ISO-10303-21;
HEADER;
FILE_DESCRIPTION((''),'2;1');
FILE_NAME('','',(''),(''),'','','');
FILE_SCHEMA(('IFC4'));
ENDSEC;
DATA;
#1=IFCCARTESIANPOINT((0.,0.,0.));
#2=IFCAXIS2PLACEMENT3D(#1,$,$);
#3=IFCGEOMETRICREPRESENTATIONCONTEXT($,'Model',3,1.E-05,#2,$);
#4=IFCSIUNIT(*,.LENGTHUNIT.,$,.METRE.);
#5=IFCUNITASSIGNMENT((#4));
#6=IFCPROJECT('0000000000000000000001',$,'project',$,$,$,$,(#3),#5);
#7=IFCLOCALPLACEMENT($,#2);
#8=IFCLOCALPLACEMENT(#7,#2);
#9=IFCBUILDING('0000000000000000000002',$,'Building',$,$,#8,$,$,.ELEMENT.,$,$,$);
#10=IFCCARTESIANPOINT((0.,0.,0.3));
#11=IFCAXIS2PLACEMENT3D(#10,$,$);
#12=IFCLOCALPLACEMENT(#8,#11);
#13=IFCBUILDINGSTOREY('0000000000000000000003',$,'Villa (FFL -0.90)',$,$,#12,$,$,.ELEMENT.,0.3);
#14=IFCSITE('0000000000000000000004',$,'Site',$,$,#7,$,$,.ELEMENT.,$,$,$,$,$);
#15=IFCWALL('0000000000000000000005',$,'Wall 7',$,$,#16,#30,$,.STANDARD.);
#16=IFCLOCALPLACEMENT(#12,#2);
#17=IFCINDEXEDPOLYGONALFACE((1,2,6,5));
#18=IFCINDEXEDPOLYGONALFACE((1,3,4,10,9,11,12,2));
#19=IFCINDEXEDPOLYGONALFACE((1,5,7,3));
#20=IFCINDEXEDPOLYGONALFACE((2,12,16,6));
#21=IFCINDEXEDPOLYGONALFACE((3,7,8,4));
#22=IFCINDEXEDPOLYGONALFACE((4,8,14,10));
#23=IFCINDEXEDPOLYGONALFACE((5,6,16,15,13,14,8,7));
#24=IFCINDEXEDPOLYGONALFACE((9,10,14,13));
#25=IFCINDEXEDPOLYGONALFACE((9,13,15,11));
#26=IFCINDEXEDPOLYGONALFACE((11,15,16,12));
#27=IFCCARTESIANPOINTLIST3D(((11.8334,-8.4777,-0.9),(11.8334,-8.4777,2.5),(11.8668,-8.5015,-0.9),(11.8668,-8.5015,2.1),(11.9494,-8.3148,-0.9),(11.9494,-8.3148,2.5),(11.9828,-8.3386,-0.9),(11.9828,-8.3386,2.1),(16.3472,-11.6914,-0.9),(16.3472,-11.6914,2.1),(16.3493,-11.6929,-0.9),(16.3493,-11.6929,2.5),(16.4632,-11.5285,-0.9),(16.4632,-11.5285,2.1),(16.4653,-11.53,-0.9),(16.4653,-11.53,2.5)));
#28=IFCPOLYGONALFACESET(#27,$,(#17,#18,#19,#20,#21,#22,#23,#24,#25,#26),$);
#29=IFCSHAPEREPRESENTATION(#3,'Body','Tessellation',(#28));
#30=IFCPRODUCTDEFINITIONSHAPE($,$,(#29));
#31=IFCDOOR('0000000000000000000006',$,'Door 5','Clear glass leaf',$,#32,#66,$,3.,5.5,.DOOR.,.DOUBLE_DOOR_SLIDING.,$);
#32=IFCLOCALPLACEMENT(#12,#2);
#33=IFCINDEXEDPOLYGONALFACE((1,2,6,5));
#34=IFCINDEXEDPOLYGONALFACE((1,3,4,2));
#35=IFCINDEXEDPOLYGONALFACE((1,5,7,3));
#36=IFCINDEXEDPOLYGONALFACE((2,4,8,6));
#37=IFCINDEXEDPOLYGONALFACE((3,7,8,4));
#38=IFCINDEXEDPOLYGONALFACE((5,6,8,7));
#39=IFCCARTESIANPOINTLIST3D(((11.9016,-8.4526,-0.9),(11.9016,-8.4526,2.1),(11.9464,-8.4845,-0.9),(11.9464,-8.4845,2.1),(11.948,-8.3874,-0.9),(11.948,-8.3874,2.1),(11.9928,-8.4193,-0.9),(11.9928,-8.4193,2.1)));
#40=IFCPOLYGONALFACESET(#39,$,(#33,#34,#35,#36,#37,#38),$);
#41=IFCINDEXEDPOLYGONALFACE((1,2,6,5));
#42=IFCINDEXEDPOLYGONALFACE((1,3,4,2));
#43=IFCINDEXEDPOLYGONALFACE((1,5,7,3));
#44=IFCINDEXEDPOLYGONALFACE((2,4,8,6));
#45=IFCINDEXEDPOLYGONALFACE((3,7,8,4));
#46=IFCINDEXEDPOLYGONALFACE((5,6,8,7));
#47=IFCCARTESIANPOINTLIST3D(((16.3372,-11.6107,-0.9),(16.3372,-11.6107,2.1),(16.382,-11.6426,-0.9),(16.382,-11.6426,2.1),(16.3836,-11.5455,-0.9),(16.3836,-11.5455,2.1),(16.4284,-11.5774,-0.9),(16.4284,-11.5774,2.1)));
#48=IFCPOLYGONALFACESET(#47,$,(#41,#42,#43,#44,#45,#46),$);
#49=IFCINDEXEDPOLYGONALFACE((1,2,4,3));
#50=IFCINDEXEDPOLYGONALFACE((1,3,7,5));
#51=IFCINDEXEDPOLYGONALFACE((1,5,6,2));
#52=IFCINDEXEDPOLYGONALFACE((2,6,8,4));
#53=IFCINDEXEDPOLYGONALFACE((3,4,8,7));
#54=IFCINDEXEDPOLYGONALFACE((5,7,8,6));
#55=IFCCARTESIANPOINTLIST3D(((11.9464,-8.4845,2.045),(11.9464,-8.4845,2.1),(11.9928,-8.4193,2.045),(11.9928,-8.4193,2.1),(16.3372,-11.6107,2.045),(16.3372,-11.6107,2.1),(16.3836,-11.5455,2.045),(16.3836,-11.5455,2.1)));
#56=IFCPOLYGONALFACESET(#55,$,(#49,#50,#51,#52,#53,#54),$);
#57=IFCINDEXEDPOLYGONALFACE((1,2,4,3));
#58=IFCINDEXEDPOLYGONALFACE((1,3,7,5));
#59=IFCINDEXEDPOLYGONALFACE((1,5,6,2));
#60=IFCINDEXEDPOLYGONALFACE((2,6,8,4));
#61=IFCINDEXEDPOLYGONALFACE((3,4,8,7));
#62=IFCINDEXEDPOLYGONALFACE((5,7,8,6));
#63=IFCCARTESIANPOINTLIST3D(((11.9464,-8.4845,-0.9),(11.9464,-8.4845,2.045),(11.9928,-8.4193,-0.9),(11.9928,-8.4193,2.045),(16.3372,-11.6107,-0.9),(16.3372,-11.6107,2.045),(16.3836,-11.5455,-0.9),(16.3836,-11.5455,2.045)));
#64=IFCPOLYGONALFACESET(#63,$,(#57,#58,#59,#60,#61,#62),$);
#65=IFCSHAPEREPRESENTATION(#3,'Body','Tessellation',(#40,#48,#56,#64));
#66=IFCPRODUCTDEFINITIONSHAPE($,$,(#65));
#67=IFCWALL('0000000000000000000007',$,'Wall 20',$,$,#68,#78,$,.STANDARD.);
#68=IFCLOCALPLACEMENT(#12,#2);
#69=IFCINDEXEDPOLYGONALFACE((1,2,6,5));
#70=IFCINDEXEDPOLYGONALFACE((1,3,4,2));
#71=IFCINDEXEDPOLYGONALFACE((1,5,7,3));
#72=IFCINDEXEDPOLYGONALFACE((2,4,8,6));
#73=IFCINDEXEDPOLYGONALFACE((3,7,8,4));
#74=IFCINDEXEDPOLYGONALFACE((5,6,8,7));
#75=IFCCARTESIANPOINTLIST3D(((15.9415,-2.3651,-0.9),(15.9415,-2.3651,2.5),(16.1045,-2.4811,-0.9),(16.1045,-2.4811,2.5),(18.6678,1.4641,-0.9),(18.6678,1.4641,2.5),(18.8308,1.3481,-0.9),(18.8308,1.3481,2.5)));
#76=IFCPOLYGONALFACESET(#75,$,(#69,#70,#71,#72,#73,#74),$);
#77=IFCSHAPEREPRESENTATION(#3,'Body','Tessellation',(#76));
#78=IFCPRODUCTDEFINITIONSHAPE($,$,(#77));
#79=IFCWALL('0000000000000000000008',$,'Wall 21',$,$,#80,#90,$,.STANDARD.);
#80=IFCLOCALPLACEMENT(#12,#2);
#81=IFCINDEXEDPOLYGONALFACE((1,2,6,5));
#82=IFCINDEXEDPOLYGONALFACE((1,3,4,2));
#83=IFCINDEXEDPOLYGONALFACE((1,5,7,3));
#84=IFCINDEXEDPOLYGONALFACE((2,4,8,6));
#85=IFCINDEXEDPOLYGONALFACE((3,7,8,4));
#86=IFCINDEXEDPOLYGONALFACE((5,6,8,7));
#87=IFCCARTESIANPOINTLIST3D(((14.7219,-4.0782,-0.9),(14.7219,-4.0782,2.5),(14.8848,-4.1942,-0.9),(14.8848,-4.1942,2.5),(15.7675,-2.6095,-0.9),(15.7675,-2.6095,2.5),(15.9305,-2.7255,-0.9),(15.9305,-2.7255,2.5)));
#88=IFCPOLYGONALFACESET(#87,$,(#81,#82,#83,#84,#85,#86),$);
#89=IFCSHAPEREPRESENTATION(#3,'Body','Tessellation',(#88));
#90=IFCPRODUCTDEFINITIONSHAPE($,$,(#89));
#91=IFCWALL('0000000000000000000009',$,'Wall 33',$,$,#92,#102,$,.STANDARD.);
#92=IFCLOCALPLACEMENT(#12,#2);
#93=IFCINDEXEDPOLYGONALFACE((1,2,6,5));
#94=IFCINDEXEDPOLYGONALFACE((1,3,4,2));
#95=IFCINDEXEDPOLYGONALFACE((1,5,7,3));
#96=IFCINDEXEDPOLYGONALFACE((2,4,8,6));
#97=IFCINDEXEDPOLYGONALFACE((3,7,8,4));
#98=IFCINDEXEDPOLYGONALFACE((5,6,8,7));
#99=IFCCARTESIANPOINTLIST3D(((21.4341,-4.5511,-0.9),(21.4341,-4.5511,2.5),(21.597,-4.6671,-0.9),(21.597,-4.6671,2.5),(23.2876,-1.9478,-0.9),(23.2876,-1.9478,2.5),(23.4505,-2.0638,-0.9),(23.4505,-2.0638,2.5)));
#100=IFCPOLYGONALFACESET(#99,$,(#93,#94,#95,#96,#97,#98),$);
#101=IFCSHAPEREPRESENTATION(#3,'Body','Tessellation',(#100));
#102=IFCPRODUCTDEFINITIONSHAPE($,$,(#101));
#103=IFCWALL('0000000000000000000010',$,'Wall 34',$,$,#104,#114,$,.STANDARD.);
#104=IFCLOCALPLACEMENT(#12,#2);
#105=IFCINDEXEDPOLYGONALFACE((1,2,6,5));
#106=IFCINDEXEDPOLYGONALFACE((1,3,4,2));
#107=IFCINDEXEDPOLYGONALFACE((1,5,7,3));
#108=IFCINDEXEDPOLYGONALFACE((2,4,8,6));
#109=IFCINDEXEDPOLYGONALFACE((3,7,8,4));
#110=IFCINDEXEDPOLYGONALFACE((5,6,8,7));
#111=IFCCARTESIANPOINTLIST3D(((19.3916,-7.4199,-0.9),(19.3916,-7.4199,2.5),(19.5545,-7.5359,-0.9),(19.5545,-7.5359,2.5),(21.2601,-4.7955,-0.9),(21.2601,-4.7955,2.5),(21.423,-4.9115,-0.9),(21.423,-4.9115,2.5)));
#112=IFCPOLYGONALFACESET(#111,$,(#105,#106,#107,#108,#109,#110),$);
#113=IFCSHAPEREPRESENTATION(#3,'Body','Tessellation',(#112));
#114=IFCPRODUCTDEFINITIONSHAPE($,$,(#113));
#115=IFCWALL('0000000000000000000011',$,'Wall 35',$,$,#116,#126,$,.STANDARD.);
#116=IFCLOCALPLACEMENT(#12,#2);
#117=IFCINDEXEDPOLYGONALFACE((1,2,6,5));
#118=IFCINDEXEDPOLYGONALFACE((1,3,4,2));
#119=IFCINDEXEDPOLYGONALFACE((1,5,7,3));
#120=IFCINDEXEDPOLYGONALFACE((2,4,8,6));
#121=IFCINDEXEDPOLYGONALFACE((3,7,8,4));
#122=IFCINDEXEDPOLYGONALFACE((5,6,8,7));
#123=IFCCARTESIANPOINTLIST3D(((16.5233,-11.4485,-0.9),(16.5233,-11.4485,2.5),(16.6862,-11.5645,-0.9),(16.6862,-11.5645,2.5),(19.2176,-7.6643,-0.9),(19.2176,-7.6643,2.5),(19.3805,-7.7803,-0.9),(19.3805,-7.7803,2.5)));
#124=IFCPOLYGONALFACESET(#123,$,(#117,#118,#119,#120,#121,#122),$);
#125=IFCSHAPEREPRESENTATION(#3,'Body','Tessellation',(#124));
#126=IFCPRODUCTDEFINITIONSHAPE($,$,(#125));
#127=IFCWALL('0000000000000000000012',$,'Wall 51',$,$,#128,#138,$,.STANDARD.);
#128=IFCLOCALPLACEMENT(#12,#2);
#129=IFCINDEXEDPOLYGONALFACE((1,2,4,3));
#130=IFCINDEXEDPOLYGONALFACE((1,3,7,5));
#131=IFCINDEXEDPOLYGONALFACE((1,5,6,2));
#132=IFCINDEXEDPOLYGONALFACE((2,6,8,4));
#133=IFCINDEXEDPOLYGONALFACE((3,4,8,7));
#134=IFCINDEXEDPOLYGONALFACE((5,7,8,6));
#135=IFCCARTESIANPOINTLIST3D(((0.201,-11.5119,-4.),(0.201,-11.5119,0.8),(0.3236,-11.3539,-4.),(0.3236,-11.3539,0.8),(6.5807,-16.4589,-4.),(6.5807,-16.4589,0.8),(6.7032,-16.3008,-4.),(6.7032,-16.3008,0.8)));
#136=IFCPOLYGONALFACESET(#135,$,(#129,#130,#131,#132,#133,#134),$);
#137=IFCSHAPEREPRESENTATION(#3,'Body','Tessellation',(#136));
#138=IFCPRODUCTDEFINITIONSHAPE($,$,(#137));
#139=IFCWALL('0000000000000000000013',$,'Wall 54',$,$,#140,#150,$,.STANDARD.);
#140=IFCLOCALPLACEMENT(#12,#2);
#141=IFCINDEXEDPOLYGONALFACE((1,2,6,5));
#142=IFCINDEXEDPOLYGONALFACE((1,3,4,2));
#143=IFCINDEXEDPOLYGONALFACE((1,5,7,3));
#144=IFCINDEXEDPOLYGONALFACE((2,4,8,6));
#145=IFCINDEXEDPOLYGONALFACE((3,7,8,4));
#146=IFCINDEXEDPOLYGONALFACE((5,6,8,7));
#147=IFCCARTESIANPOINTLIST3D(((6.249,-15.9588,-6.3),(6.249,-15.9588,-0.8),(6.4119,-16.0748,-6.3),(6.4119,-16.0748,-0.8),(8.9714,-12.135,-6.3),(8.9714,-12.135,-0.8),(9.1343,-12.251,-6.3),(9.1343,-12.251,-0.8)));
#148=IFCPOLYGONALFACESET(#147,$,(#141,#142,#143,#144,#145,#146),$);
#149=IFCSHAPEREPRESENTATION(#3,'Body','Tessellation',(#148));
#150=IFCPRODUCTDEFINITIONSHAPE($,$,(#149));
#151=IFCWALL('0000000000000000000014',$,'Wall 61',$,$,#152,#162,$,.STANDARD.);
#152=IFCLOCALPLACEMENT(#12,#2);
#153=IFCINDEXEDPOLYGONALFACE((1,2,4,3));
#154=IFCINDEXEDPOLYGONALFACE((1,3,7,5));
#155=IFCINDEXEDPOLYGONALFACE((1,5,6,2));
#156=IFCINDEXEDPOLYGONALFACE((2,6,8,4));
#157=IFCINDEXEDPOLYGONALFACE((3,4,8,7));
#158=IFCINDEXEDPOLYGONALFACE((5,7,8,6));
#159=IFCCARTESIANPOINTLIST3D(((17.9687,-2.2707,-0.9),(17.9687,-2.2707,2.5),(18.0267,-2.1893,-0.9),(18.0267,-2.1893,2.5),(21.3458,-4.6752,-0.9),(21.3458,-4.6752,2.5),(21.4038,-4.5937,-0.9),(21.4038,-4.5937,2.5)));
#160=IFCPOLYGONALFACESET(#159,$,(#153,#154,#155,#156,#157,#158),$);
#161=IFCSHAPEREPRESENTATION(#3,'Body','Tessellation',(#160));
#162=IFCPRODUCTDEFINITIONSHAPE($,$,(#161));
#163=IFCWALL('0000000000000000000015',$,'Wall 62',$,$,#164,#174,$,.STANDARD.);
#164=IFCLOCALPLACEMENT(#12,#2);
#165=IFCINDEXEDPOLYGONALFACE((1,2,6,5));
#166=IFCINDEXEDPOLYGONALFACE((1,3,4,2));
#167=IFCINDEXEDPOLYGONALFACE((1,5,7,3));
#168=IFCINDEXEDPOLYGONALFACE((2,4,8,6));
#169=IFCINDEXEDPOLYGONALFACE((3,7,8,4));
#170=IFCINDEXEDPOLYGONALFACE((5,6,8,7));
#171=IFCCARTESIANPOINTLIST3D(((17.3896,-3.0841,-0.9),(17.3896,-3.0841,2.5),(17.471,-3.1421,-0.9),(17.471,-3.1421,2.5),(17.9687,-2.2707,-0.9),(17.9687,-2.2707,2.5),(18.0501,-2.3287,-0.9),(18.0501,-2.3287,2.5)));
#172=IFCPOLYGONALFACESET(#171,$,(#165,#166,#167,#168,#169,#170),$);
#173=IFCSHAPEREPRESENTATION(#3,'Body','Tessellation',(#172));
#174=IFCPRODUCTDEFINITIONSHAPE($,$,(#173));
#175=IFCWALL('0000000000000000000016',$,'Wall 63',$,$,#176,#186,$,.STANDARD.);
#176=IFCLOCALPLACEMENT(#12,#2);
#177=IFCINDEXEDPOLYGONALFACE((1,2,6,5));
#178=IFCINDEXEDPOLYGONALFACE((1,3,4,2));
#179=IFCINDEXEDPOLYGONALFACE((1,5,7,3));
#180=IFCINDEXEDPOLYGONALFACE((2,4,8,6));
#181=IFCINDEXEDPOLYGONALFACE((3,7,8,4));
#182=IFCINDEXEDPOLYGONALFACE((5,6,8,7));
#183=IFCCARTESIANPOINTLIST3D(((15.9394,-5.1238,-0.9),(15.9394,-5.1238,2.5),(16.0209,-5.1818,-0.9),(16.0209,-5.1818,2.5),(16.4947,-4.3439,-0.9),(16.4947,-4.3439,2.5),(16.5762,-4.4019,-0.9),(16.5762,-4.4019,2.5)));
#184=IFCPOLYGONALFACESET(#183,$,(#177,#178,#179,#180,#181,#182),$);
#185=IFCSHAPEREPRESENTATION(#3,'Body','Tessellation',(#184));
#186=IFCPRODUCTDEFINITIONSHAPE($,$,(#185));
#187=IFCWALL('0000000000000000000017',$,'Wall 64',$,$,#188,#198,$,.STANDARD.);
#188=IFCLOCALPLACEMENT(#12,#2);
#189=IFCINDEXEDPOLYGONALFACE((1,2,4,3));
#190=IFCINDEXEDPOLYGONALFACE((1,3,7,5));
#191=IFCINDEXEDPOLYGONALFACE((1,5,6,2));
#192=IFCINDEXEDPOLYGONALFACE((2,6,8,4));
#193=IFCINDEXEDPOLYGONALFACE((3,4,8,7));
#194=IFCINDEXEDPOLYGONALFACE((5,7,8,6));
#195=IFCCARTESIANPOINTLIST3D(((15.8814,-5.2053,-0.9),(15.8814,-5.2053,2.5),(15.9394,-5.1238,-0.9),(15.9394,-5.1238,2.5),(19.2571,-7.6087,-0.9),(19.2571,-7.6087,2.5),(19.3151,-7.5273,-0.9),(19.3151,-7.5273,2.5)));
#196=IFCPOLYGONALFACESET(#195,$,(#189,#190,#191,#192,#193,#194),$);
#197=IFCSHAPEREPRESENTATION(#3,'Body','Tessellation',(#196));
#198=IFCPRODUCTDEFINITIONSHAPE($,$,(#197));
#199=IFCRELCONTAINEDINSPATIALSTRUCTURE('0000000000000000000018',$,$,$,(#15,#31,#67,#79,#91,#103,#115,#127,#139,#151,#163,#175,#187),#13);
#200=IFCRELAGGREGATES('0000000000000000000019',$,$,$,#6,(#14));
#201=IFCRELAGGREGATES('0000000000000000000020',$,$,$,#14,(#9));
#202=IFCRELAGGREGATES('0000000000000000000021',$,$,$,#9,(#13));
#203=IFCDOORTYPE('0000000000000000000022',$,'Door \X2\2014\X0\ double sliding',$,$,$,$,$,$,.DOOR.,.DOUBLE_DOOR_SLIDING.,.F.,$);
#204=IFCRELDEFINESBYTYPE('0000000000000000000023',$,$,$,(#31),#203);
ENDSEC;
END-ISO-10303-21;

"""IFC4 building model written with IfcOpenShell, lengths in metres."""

from ifc_helpers import new_model, si_unit, frame, frame_2d, origin, place, context, project, spatial, rectangle, extrude, type_object, element, fill, save


model = new_model("IFC4")

# Units and contexts
model_context = context("Model", 3, precision=1e-05, world=origin())
ifc_project = project(units=[si_unit("LENGTHUNIT", "METRE")], contexts=[model_context])

# Site, building, storey
site_placement = place(None, origin())
site = spatial("IfcSite", under=ifc_project, at=site_placement, Name="Site", CompositionType="ELEMENT")
building_placement = place(site_placement, origin())
building = spatial("IfcBuilding", under=site, at=building_placement, Name="Building", CompositionType="ELEMENT")
storey_placement = place(building_placement, frame((0.0, 0.0, 0.3)))
storey = spatial("IfcBuildingStorey", under=building, at=storey_placement, Name="Villa (FFL -0.90)", CompositionType="ELEMENT", Elevation=0.3)

# Wall, opening, door
door_type = type_object("IfcDoorType", Name="Door — double sliding", OperationType="DOUBLE_DOOR_SLIDING", ParameterTakesPrecedence=False, PredefinedType="DOOR")
wall_1_placement = place(storey_placement, frame((11.8914, -8.3962, -0.9), z_axis=(0.0, 0.0, 1.0), x_axis=(0.814622, -0.579992, 0.0)))
wall_1 = element("IfcWall", 1, at=wall_1_placement, inside=storey, Name="Wall 7", PredefinedType="STANDARD", context=model_context, shape_type="SweptSolid", body=[
    extrude(rectangle(XDim=5.5436, YDim=0.2, at=frame_2d((2.7718, 0.0))), origin(), (0.0, 0.0, 1.0), 3.4),
])
opening_1_placement = place(storey_placement, frame((11.9248, -8.42, -0.9), z_axis=(0.0, 0.0, 1.0), x_axis=(0.814622, -0.579992, 0.0)))
opening_1 = element("IfcOpeningElement", 2, at=opening_1_placement, cuts=wall_1, PredefinedType="OPENING", context=model_context, shape_type="SweptSolid", body=[
    extrude(rectangle(XDim=5.5, YDim=0.26, at=frame_2d((2.75, 0.0))), origin(), (0.0, 0.0, 1.0), 3.0),
])
door_1_placement = place(storey_placement, frame((11.9248, -8.42, -0.9), z_axis=(0.0, 0.0, 1.0), x_axis=(0.814622, -0.579992, 0.0)))
door_1 = element("IfcDoor", 3, at=door_1_placement, inside=storey, type_object=door_type, Name="Door 5", Description="Clear glass leaf", OperationType="DOUBLE_DOOR_SLIDING", OverallHeight=3.0, OverallWidth=5.5, PredefinedType="DOOR", context=model_context, shape_type="SweptSolid", body=[
    extrude(rectangle(XDim=0.055, YDim=0.08, at=frame_2d((0.0275, 0.0))), origin(), (0.0, 0.0, 1.0), 3.0),
    extrude(rectangle(XDim=0.055, YDim=0.08, at=frame_2d((5.4725, 0.0))), origin(), (0.0, 0.0, 1.0), 3.0),
    extrude(rectangle(XDim=5.39, YDim=0.08, at=frame_2d((2.75, 0.0))), frame((0.0, 0.0, 2.945)), (0.0, 0.0, 1.0), 0.055),
    extrude(rectangle(XDim=5.39, YDim=0.08, at=frame_2d((2.75, 0.0))), origin(), (0.0, 0.0, 1.0), 2.945),
])
fill(opening_1, door_1)

# Walls
wall_2_placement = place(storey_placement, frame((16.023, -2.4231, -0.9), z_axis=(0.0, 0.0, 1.0), x_axis=(0.579992, 0.814622, 0.0)))
element("IfcWall", 4, at=wall_2_placement, inside=storey, Name="Wall 20", PredefinedType="STANDARD", context=model_context, shape_type="SweptSolid", body=[
    extrude(rectangle(XDim=4.7006, YDim=0.2, at=frame_2d((2.3503, 0.0))), origin(), (0.0, 0.0, 1.0), 3.4),
])
wall_3_placement = place(storey_placement, frame((14.8033, -4.1362, -0.9), z_axis=(0.0, 0.0, 1.0), x_axis=(0.579992, 0.814622, 0.0)))
element("IfcWall", 5, at=wall_3_placement, inside=storey, Name="Wall 21", PredefinedType="STANDARD", context=model_context, shape_type="SweptSolid", body=[
    extrude(rectangle(XDim=1.8029, YDim=0.2, at=frame_2d((0.9014, 0.0))), origin(), (0.0, 0.0, 1.0), 3.4),
])
wall_4_placement = place(storey_placement, frame((21.5156, -4.6091, -0.9), z_axis=(0.0, 0.0, 1.0), x_axis=(0.579992, 0.814622, 0.0)))
element("IfcWall", 6, at=wall_4_placement, inside=storey, Name="Wall 33", PredefinedType="STANDARD", context=model_context, shape_type="SweptSolid", body=[
    extrude(rectangle(XDim=3.1957, YDim=0.2, at=frame_2d((1.5978, 0.0))), origin(), (0.0, 0.0, 1.0), 3.4),
])
wall_5_placement = place(storey_placement, frame((19.473, -7.4779, -0.9), z_axis=(0.0, 0.0, 1.0), x_axis=(0.579992, 0.814622, 0.0)))
element("IfcWall", 7, at=wall_5_placement, inside=storey, Name="Wall 34", PredefinedType="STANDARD", context=model_context, shape_type="SweptSolid", body=[
    extrude(rectangle(XDim=3.2217, YDim=0.2, at=frame_2d((1.6108, 0.0))), origin(), (0.0, 0.0, 1.0), 3.4),
])
wall_6_placement = place(storey_placement, frame((16.6047, -11.5065, -0.9), z_axis=(0.0, 0.0, 1.0), x_axis=(0.579992, 0.814622, 0.0)))
element("IfcWall", 8, at=wall_6_placement, inside=storey, Name="Wall 35", PredefinedType="STANDARD", context=model_context, shape_type="SweptSolid", body=[
    extrude(rectangle(XDim=4.6454, YDim=0.2, at=frame_2d((2.3227, 0.0))), origin(), (0.0, 0.0, 1.0), 3.4),
])
wall_7_placement = place(storey_placement, frame((0.2623, -11.4329, -4.0), z_axis=(0.0, 0.0, 1.0), x_axis=(0.790251, -0.612783, 0.0)))
element("IfcWall", 9, at=wall_7_placement, inside=storey, Name="Wall 51", PredefinedType="STANDARD", context=model_context, shape_type="SweptSolid", body=[
    extrude(rectangle(XDim=8.0729, YDim=0.2, at=frame_2d((4.0365, 0.0))), origin(), (0.0, 0.0, 1.0), 4.8),
])
wall_8_placement = place(storey_placement, frame((9.0529, -12.193, -6.3), z_axis=(0.0, 0.0, 1.0), x_axis=(-0.579992, -0.814622, 0.0)))
element("IfcWall", 10, at=wall_8_placement, inside=storey, Name="Wall 54", PredefinedType="STANDARD", context=model_context, shape_type="SweptSolid", body=[
    extrude(rectangle(XDim=4.6939, YDim=0.2, at=frame_2d((2.347, 0.0))), origin(), (0.0, 0.0, 1.0), 5.5),
])
wall_9_placement = place(storey_placement, frame((17.9977, -2.23, -0.9), z_axis=(0.0, 0.0, 1.0), x_axis=(0.814622, -0.579992, 0.0)))
element("IfcWall", 11, at=wall_9_placement, inside=storey, Name="Wall 61", PredefinedType="STANDARD", context=model_context, shape_type="SweptSolid", body=[
    extrude(rectangle(XDim=4.1456, YDim=0.1, at=frame_2d((2.0728, 0.0))), origin(), (0.0, 0.0, 1.0), 3.4),
])
wall_10_placement = place(storey_placement, frame((17.4303, -3.1131, -0.9), z_axis=(0.0, 0.0, 1.0), x_axis=(0.579992, 0.814622, 0.0)))
element("IfcWall", 12, at=wall_10_placement, inside=storey, Name="Wall 62", PredefinedType="STANDARD", context=model_context, shape_type="SweptSolid", body=[
    extrude(rectangle(XDim=0.9985, YDim=0.1, at=frame_2d((0.4992, 0.0))), origin(), (0.0, 0.0, 1.0), 3.4),
])
wall_11_placement = place(storey_placement, frame((15.9801, -5.1528, -0.9), z_axis=(0.0, 0.0, 1.0), x_axis=(0.579992, 0.814622, 0.0)))
element("IfcWall", 13, at=wall_11_placement, inside=storey, Name="Wall 63", PredefinedType="STANDARD", context=model_context, shape_type="SweptSolid", body=[
    extrude(rectangle(XDim=0.9574, YDim=0.1, at=frame_2d((0.4787, 0.0))), origin(), (0.0, 0.0, 1.0), 3.4),
])
wall_12_placement = place(storey_placement, frame((15.9104, -5.1645, -0.9), z_axis=(0.0, 0.0, 1.0), x_axis=(0.814622, -0.579992, 0.0)))
element("IfcWall", 14, at=wall_12_placement, inside=storey, Name="Wall 64", PredefinedType="STANDARD", context=model_context, shape_type="SweptSolid", body=[
    extrude(rectangle(XDim=4.1439, YDim=0.1, at=frame_2d((2.072, 0.0))), origin(), (0.0, 0.0, 1.0), 3.4),
])

save(model, "model.ifc")
